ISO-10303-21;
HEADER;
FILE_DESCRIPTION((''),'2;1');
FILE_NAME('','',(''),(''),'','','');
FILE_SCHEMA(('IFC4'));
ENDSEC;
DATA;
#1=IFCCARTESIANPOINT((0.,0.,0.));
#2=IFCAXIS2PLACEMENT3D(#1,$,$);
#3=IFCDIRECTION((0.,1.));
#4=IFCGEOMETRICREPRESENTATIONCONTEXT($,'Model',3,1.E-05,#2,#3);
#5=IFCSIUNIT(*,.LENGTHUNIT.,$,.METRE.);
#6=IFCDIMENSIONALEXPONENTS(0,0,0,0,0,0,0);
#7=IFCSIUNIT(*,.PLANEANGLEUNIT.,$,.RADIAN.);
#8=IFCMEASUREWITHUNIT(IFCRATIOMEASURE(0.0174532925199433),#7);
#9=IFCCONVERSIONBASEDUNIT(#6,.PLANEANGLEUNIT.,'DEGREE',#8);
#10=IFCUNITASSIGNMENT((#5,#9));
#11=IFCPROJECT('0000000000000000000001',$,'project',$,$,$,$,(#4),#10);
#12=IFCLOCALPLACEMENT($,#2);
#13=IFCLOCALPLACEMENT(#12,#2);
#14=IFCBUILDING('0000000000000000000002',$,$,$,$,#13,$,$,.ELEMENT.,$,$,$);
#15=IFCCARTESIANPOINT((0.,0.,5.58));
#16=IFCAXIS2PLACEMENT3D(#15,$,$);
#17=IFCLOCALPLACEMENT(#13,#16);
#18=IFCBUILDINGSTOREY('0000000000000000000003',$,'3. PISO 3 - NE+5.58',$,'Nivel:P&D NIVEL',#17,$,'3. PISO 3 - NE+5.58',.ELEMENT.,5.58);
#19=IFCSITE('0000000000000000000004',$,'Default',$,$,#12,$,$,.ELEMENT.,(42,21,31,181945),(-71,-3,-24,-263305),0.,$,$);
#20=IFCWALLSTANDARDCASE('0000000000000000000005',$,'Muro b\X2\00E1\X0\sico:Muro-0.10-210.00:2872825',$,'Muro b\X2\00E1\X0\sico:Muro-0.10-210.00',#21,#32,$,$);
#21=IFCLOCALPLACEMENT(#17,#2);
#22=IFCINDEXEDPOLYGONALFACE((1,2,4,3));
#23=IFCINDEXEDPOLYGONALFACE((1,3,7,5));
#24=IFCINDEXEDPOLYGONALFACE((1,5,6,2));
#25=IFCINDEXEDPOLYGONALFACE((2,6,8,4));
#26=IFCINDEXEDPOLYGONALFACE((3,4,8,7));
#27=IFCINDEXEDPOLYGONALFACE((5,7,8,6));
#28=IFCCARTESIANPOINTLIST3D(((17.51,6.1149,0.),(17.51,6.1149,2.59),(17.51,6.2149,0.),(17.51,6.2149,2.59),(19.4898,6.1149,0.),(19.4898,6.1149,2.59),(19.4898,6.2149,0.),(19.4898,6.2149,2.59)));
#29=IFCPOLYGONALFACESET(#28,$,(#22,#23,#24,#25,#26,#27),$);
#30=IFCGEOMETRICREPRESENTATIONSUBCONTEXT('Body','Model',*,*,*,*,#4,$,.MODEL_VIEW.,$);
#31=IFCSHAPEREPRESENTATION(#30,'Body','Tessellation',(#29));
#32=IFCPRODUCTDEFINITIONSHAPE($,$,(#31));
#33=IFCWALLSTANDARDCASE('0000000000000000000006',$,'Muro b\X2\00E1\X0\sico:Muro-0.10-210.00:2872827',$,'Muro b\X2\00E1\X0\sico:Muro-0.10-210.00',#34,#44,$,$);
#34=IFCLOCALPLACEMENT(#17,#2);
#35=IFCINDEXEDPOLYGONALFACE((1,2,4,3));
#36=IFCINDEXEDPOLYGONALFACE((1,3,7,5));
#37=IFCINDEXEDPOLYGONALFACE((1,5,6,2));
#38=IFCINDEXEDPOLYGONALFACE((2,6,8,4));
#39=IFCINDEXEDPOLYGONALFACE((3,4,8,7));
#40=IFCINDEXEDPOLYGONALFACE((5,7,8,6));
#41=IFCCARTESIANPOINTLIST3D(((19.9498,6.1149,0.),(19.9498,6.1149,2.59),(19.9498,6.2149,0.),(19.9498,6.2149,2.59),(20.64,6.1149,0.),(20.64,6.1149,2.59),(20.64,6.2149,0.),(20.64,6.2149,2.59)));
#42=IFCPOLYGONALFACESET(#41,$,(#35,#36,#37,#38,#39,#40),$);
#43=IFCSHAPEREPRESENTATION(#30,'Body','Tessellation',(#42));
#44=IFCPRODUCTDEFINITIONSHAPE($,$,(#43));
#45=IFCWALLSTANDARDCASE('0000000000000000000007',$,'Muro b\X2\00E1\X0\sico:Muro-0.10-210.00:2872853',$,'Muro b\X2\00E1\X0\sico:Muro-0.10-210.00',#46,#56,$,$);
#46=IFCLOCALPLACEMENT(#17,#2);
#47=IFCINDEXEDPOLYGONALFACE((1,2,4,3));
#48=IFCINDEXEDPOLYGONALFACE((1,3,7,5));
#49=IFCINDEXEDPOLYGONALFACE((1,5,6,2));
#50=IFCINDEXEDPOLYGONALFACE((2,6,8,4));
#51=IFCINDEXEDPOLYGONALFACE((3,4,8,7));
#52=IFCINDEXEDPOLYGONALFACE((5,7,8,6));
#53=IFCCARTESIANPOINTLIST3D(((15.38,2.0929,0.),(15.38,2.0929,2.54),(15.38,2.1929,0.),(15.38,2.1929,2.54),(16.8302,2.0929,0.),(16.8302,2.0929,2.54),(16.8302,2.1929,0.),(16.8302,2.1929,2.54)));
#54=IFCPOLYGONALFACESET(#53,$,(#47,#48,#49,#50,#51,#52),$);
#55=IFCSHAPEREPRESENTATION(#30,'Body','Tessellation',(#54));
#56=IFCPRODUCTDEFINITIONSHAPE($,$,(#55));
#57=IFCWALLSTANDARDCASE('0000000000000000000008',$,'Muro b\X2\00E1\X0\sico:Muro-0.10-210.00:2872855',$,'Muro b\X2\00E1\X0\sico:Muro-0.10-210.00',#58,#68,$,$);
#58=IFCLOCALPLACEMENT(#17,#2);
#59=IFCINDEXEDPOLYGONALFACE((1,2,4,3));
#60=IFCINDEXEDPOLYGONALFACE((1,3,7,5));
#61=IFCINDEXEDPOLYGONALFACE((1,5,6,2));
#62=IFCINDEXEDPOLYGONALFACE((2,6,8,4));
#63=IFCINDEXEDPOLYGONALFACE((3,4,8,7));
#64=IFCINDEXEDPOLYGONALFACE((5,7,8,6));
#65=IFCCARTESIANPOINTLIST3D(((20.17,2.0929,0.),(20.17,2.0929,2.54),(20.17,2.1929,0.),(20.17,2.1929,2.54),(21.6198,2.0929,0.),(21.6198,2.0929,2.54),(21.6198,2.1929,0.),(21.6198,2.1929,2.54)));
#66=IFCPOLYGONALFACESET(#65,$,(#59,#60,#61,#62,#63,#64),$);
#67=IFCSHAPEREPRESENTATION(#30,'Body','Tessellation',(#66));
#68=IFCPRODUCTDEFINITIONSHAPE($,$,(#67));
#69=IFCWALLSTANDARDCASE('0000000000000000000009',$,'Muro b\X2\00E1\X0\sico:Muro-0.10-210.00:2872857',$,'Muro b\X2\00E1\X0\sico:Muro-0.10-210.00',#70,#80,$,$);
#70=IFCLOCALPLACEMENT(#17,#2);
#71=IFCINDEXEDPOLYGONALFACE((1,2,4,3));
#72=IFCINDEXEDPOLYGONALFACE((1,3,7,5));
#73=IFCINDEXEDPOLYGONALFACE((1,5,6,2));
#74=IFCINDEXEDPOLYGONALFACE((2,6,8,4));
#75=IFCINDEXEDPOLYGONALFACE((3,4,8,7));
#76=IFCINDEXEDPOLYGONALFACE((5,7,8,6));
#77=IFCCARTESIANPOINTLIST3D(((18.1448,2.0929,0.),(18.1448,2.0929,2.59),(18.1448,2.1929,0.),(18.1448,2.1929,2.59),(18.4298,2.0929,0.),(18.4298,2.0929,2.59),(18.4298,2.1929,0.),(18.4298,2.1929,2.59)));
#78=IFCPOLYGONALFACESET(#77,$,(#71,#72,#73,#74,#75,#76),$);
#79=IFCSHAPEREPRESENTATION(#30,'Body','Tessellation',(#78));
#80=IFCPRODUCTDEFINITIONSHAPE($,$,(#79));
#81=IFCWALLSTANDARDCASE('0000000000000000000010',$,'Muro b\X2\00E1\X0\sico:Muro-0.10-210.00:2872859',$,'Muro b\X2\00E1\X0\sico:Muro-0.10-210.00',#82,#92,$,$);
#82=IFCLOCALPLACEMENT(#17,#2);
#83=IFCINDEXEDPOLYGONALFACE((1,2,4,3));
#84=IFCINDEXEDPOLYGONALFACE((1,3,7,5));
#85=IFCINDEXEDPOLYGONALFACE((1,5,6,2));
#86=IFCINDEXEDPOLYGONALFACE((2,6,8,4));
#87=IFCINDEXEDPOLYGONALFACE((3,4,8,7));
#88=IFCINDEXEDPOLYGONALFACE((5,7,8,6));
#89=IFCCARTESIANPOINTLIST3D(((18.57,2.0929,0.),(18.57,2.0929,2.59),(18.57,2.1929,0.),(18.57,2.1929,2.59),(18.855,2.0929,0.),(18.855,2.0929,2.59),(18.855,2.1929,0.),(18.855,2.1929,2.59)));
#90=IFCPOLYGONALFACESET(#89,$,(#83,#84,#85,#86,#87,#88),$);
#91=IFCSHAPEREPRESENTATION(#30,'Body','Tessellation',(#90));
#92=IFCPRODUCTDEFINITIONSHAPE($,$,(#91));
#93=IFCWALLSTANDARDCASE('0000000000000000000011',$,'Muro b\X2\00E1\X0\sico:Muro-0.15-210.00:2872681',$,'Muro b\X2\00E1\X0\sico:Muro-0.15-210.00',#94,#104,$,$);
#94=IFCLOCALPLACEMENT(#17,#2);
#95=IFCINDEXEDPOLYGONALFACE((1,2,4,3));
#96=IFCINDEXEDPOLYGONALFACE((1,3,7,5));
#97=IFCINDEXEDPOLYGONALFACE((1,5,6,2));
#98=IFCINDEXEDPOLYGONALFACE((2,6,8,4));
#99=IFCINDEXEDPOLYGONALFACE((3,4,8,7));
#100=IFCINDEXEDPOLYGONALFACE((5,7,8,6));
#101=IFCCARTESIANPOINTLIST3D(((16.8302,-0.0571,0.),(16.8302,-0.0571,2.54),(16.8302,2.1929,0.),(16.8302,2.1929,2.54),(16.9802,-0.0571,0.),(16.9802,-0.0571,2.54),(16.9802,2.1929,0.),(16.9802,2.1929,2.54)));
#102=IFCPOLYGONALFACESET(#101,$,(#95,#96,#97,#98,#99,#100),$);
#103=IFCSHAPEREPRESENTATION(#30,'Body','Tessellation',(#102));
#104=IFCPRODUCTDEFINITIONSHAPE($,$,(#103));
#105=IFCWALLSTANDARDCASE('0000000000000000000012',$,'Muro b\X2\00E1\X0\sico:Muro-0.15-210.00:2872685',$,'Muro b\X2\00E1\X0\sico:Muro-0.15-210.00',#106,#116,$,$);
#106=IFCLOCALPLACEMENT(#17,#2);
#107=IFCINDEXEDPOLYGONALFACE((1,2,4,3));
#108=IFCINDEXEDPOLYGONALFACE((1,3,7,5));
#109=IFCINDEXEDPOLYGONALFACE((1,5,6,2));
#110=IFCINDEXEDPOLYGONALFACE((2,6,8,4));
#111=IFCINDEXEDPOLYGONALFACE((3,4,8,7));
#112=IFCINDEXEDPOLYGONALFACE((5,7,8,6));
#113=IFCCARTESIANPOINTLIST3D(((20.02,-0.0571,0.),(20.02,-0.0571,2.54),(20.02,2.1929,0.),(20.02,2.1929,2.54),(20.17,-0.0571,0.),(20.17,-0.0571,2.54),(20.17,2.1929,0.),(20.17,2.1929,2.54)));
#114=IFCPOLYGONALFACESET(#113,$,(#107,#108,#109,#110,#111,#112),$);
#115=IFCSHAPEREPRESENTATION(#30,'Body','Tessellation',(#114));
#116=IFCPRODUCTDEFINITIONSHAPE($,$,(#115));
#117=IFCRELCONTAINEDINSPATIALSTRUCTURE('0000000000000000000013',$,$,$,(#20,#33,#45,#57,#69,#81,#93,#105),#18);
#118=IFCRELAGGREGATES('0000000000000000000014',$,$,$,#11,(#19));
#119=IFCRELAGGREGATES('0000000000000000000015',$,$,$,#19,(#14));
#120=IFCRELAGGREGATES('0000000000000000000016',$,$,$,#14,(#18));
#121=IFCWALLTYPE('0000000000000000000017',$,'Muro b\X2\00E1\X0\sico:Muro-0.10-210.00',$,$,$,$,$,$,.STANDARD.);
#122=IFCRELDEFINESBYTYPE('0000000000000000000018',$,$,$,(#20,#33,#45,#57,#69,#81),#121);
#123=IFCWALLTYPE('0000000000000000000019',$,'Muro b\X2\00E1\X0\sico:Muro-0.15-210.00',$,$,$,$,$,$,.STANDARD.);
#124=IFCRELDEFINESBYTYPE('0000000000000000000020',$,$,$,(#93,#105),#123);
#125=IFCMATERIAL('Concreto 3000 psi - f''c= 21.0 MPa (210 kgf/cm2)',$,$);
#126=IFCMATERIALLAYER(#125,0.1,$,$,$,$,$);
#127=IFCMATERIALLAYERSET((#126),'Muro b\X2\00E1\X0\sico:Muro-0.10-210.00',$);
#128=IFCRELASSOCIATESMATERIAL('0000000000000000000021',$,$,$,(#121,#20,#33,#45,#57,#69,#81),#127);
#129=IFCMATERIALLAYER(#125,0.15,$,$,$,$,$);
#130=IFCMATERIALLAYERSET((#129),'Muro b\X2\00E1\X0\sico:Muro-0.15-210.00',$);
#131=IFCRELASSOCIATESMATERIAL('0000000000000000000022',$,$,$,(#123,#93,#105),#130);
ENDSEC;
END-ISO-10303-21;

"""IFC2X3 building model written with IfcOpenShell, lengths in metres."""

from ifc_helpers import new_model, entity, si_unit, converted_unit, direction, frame, frame_2d, origin, place, context, subcontext, project, spatial, rectangle, extrude, material, layer, layer_set, layer_usage, type_object, element, save


model = new_model("IFC2X3")

# Units and contexts
model_context = context("Model", 3, precision=1e-05, world=origin(), true_north=direction((0.0, 1.0)))
body_context = subcontext(model_context, "Body", "Model", "MODEL_VIEW")
ifc_project = project(units=[si_unit("LENGTHUNIT", "METRE"), converted_unit("PLANEANGLEUNIT", "DEGREE", entity("IfcRatioMeasure", 0.0174532925199433), si_unit("PLANEANGLEUNIT", "RADIAN"), dimensions=[0, 0, 0, 0, 0, 0, 0])], contexts=[model_context])

# Site, building, storey
site_placement = place(None, origin())
site = spatial("IfcSite", under=ifc_project, at=site_placement, Name="Default", CompositionType="ELEMENT", RefLatitude=(42, 21, 31, 181945), RefLongitude=(-71, -3, -24, -263305), RefElevation=0.0)
building_placement = place(site_placement, origin())
building = spatial("IfcBuilding", under=site, at=building_placement, CompositionType="ELEMENT")
storey_placement = place(building_placement, frame((0.0, 0.0, 5.58)))
storey = spatial("IfcBuildingStorey", under=building, at=storey_placement, Name="3. PISO 3 - NE+5.58", ObjectType="Nivel:P&D NIVEL", LongName="3. PISO 3 - NE+5.58", CompositionType="ELEMENT", Elevation=5.58)

# Shared definitions
ifc_material = material(Name="Concreto 3000 psi - f'c= 21.0 MPa (210 kgf/cm2)")

# Walls
ifc_layer_1 = layer(ifc_material, 0.1)
ifc_layer_set_1 = layer_set([ifc_layer_1], Name="Muro básico:Muro-0.10-210.00")
ifc_layer_usage_1 = layer_usage(ifc_layer_set_1, "AXIS2", "POSITIVE", -0.05)
wall_type_1 = type_object("IfcWallType", Name="Muro básico:Muro-0.10-210.00", PredefinedType="STANDARD", material=ifc_layer_set_1)
wall_1_placement = place(storey_placement, frame((17.51, 6.1649, 0.0)))
element("IfcWallStandardCase", 1, at=wall_1_placement, inside=storey, type_object=wall_type_1, material=ifc_layer_usage_1, Name="Muro básico:Muro-0.10-210.00:2872825", ObjectType="Muro básico:Muro-0.10-210.00", context=body_context, shape_type="SweptSolid", body=[
    extrude(rectangle(XDim=1.9798, YDim=0.1, at=frame_2d((0.9899, 0.0), x_axis=(-1.0, 0.0))), origin(), (0.0, 0.0, 1.0), 2.59),
])
wall_2_placement = place(storey_placement, frame((19.9498, 6.1649, 0.0)))
element("IfcWallStandardCase", 2, at=wall_2_placement, inside=storey, type_object=wall_type_1, material=ifc_layer_usage_1, Name="Muro básico:Muro-0.10-210.00:2872827", ObjectType="Muro básico:Muro-0.10-210.00", context=body_context, shape_type="SweptSolid", body=[
    extrude(rectangle(XDim=0.6902, YDim=0.1, at=frame_2d((0.3451, 0.0), x_axis=(-1.0, 0.0))), origin(), (0.0, 0.0, 1.0), 2.59),
])
wall_3_placement = place(storey_placement, frame((15.38, 2.1429, 0.0)))
element("IfcWallStandardCase", 3, at=wall_3_placement, inside=storey, type_object=wall_type_1, material=ifc_layer_usage_1, Name="Muro básico:Muro-0.10-210.00:2872853", ObjectType="Muro básico:Muro-0.10-210.00", context=body_context, shape_type="SweptSolid", body=[
    extrude(rectangle(XDim=1.4502, YDim=0.1, at=frame_2d((0.7251, 0.0), x_axis=(-1.0, 0.0))), origin(), (0.0, 0.0, 1.0), 2.54),
])
wall_4_placement = place(storey_placement, frame((20.17, 2.1429, 0.0)))
element("IfcWallStandardCase", 4, at=wall_4_placement, inside=storey, type_object=wall_type_1, material=ifc_layer_usage_1, Name="Muro básico:Muro-0.10-210.00:2872855", ObjectType="Muro básico:Muro-0.10-210.00", context=body_context, shape_type="SweptSolid", body=[
    extrude(rectangle(XDim=1.4498, YDim=0.1, at=frame_2d((0.7249, 0.0), x_axis=(-1.0, 0.0))), origin(), (0.0, 0.0, 1.0), 2.54),
])
wall_5_placement = place(storey_placement, frame((18.1448, 2.1429, 0.0)))
element("IfcWallStandardCase", 5, at=wall_5_placement, inside=storey, type_object=wall_type_1, material=ifc_layer_usage_1, Name="Muro básico:Muro-0.10-210.00:2872857", ObjectType="Muro básico:Muro-0.10-210.00", context=body_context, shape_type="SweptSolid", body=[
    extrude(rectangle(XDim=0.285, YDim=0.1, at=frame_2d((0.1425, 0.0), x_axis=(-1.0, 0.0))), origin(), (0.0, 0.0, 1.0), 2.59),
])
wall_6_placement = place(storey_placement, frame((18.57, 2.1429, 0.0)))
element("IfcWallStandardCase", 6, at=wall_6_placement, inside=storey, type_object=wall_type_1, material=ifc_layer_usage_1, Name="Muro básico:Muro-0.10-210.00:2872859", ObjectType="Muro básico:Muro-0.10-210.00", context=body_context, shape_type="SweptSolid", body=[
    extrude(rectangle(XDim=0.285, YDim=0.1, at=frame_2d((0.1425, 0.0), x_axis=(-1.0, 0.0))), origin(), (0.0, 0.0, 1.0), 2.59),
])
ifc_layer_2 = layer(ifc_material, 0.15)
ifc_layer_set_2 = layer_set([ifc_layer_2], Name="Muro básico:Muro-0.15-210.00")
ifc_layer_usage_2 = layer_usage(ifc_layer_set_2, "AXIS2", "POSITIVE", -0.075)
wall_type_2 = type_object("IfcWallType", Name="Muro básico:Muro-0.15-210.00", PredefinedType="STANDARD", material=ifc_layer_set_2)
wall_7_placement = place(storey_placement, frame((16.9052, -0.0571, 0.0), z_axis=(0.0, 0.0, 1.0), x_axis=(0.0, 1.0, 0.0)))
element("IfcWallStandardCase", 7, at=wall_7_placement, inside=storey, type_object=wall_type_2, material=ifc_layer_usage_2, Name="Muro básico:Muro-0.15-210.00:2872681", ObjectType="Muro básico:Muro-0.15-210.00", context=body_context, shape_type="SweptSolid", body=[
    extrude(rectangle(XDim=2.25, YDim=0.15, at=frame_2d((1.125, 0.0), x_axis=(-1.0, 0.0))), origin(), (0.0, 0.0, 1.0), 2.54),
])
wall_8_placement = place(storey_placement, frame((20.095, -0.0571, 0.0), z_axis=(0.0, 0.0, 1.0), x_axis=(0.0, 1.0, 0.0)))
element("IfcWallStandardCase", 8, at=wall_8_placement, inside=storey, type_object=wall_type_2, material=ifc_layer_usage_2, Name="Muro básico:Muro-0.15-210.00:2872685", ObjectType="Muro básico:Muro-0.15-210.00", context=body_context, shape_type="SweptSolid", body=[
    extrude(rectangle(XDim=2.25, YDim=0.15, at=frame_2d((1.125, 0.0), x_axis=(-1.0, 0.0))), origin(), (0.0, 0.0, 1.0), 2.54),
])

save(model, "model.ifc")
